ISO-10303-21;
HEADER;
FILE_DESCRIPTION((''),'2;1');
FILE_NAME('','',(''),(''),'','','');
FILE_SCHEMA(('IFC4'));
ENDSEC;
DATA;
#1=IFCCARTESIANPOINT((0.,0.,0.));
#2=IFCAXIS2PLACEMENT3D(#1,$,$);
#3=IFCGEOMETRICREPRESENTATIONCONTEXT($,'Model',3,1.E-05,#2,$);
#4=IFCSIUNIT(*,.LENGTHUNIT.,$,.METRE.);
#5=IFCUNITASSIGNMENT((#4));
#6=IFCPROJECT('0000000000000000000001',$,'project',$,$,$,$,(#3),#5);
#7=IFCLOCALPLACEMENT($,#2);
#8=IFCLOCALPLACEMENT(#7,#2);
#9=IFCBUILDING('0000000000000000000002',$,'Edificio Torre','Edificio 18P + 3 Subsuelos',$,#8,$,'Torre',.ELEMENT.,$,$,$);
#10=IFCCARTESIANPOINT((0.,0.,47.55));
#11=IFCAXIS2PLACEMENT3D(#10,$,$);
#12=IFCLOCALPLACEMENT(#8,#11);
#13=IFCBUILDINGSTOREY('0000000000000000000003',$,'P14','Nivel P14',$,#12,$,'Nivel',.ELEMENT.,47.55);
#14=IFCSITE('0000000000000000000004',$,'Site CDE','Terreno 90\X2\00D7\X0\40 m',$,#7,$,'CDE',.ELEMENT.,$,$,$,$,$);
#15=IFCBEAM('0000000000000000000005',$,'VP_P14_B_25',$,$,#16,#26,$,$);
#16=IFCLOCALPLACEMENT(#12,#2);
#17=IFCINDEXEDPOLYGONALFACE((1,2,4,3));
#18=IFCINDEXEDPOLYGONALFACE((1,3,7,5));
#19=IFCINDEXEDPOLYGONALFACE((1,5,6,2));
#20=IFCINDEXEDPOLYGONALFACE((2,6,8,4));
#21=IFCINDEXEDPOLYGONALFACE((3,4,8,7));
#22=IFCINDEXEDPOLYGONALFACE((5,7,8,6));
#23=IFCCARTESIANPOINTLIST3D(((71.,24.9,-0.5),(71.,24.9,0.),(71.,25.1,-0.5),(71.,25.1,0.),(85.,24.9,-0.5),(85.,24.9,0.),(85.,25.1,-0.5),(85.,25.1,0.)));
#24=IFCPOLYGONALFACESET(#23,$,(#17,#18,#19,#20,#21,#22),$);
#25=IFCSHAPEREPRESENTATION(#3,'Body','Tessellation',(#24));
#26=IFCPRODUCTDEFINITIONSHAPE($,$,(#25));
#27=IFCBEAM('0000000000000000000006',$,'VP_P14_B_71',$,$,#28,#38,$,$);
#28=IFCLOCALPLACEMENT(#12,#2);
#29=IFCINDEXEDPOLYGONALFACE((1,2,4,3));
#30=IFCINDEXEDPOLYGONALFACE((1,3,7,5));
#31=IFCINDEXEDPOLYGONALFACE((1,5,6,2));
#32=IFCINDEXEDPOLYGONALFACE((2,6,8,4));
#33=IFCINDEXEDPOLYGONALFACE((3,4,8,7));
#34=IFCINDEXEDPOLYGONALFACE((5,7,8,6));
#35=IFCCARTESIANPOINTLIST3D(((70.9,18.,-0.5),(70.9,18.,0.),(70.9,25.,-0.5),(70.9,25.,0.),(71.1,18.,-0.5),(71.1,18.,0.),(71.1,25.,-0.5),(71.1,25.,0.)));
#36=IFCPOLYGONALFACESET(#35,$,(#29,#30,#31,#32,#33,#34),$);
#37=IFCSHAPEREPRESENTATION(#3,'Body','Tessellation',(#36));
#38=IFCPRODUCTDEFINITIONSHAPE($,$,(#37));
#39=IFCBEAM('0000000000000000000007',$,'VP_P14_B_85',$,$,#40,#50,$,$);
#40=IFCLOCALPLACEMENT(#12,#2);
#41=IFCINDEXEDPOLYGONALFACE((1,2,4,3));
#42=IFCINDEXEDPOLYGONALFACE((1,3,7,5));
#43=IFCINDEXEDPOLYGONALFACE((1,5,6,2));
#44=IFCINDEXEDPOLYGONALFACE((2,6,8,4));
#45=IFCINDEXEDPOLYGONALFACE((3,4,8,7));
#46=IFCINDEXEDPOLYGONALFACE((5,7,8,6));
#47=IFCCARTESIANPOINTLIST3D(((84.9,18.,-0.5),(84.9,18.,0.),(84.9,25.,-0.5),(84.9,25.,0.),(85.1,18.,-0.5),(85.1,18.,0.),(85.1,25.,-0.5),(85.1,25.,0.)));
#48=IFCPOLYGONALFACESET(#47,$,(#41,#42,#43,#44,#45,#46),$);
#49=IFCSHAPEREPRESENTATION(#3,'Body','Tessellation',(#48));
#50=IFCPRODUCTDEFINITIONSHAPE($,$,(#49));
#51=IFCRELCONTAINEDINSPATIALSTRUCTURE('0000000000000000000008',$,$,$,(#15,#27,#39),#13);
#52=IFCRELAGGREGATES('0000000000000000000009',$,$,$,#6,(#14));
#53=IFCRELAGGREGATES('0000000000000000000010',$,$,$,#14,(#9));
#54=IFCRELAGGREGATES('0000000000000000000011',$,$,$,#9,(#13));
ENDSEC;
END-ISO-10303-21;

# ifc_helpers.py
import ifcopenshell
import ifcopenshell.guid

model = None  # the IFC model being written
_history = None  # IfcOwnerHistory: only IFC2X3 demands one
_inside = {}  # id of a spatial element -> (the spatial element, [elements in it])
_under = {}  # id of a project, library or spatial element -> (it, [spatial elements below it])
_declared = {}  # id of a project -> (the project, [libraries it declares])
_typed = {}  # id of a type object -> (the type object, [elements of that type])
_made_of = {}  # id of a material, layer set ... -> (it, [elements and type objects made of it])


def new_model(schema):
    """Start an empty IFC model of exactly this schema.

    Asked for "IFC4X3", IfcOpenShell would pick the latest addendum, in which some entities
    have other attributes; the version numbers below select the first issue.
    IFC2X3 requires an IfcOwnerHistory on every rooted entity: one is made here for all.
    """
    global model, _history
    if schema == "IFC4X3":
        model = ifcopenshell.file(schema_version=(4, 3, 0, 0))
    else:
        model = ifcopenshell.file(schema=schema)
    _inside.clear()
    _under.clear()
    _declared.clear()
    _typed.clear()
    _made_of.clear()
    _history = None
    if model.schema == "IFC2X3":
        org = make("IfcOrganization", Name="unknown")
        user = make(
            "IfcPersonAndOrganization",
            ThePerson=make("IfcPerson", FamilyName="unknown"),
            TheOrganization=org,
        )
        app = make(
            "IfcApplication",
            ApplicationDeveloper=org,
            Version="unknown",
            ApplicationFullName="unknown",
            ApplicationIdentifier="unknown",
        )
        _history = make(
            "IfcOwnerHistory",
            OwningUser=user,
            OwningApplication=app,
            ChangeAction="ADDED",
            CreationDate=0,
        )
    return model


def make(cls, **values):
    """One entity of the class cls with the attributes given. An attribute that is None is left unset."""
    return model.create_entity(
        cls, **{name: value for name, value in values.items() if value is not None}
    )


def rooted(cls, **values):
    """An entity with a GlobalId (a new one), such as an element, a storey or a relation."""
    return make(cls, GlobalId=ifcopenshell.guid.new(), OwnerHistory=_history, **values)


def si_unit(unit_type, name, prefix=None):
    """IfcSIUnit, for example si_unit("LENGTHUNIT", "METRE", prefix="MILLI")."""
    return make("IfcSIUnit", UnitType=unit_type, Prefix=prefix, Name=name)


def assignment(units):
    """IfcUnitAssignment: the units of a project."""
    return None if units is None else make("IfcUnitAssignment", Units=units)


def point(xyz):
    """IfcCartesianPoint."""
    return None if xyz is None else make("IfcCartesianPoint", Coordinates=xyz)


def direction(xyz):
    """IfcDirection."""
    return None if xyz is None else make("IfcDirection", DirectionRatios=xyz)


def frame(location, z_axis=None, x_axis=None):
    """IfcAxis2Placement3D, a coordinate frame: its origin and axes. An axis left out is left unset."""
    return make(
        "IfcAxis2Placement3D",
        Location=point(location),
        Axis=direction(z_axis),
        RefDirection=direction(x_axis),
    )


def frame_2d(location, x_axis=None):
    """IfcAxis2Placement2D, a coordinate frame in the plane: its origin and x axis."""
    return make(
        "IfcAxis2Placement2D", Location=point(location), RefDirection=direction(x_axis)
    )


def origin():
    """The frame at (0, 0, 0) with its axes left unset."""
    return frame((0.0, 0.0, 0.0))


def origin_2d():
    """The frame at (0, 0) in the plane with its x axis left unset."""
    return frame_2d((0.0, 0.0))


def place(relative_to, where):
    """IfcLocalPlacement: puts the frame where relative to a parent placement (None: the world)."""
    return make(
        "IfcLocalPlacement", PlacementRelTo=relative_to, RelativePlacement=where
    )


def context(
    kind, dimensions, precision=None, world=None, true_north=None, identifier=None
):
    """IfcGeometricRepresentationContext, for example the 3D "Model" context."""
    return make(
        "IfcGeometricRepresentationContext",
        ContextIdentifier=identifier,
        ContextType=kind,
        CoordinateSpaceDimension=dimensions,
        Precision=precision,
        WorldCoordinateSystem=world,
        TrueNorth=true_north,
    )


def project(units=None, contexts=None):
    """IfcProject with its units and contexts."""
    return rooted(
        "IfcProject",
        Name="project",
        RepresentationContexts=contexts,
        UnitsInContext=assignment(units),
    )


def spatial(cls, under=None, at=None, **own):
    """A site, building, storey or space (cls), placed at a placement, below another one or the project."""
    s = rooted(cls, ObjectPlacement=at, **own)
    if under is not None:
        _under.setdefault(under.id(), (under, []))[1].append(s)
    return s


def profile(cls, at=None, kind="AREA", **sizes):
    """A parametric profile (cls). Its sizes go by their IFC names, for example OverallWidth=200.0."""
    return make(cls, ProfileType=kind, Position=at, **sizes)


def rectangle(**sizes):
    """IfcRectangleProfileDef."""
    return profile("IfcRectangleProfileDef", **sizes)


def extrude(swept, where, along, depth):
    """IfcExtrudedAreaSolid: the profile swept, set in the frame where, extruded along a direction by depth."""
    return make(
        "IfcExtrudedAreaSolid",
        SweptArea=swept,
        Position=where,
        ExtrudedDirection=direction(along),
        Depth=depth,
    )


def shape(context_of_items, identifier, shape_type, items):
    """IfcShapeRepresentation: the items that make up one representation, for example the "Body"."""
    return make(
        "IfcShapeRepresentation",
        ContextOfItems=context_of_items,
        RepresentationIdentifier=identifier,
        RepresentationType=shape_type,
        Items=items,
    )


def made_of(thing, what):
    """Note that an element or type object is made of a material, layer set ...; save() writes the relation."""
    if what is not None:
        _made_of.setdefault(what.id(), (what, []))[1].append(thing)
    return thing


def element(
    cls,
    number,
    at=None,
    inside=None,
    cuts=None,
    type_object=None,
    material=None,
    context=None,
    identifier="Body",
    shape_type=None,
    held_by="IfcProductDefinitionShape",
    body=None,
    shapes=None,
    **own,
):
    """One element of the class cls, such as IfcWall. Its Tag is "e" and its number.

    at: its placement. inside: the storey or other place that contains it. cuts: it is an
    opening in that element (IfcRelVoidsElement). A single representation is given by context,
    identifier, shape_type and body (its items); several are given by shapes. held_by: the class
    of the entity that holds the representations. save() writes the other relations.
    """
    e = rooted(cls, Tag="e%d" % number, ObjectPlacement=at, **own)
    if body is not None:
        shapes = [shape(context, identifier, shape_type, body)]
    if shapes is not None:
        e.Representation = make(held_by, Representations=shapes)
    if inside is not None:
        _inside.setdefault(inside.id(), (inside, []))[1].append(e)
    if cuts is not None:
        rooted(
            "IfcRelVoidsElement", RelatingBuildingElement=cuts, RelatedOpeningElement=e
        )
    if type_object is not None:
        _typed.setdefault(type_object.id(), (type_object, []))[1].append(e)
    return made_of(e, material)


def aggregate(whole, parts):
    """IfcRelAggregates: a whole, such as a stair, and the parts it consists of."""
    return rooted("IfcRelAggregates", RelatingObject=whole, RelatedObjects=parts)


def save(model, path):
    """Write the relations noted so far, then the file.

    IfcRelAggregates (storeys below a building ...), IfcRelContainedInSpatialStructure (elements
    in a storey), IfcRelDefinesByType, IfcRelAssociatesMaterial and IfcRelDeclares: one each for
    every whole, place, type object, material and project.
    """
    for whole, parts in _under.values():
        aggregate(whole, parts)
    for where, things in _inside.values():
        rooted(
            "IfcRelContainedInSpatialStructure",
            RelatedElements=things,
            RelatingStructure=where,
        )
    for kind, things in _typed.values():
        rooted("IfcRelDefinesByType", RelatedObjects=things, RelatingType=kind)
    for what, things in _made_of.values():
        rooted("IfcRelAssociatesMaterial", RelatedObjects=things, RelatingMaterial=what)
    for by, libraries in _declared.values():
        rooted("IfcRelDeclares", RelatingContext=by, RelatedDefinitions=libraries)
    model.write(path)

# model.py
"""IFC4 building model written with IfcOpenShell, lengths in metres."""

from ifc_helpers import new_model, si_unit, frame, origin, origin_2d, place, context, project, spatial, rectangle, extrude, element, save


model = new_model("IFC4")

# Units and contexts
model_context = context("Model", 3, precision=1e-05, world=origin())
ifc_project = project(units=[si_unit("LENGTHUNIT", "METRE")], contexts=[model_context])

# Site, building, storey
site_placement = place(None, origin())
site = spatial("IfcSite", under=ifc_project, at=site_placement, Name="Site CDE", Description="Terreno 90×40 m", LongName="CDE", CompositionType="ELEMENT")
building_placement = place(site_placement, origin())
building = spatial("IfcBuilding", under=site, at=building_placement, Name="Edificio Torre", Description="Edificio 18P + 3 Subsuelos", LongName="Torre", CompositionType="ELEMENT")
storey_placement = place(building_placement, frame((0.0, 0.0, 47.55)))
storey = spatial("IfcBuildingStorey", under=building, at=storey_placement, Name="P14", Description="Nivel P14", LongName="Nivel", CompositionType="ELEMENT", Elevation=47.55)

# Beams
for number, where, name in (
    (1, (78.0, 25.0, -0.5), "VP_P14_B_25"),
):
    element("IfcBeam", number, at=place(storey_placement, frame(where)), inside=storey, Name=name, context=model_context, shape_type="SweptSolid", body=[
        extrude(rectangle(XDim=14.0, YDim=0.2, at=origin_2d()), origin(), (0.0, 0.0, 1.0), 0.5),
    ])
for number, where, name in (
    (2, (71.0, 21.5, -0.5), "VP_P14_B_71"),
    (3, (85.0, 21.5, -0.5), "VP_P14_B_85"),
):
    element("IfcBeam", number, at=place(storey_placement, frame(where)), inside=storey, Name=name, context=model_context, shape_type="SweptSolid", body=[
        extrude(rectangle(XDim=0.2, YDim=7.0, at=origin_2d()), origin(), (0.0, 0.0, 1.0), 0.5),
    ])

save(model, "model.ifc")
